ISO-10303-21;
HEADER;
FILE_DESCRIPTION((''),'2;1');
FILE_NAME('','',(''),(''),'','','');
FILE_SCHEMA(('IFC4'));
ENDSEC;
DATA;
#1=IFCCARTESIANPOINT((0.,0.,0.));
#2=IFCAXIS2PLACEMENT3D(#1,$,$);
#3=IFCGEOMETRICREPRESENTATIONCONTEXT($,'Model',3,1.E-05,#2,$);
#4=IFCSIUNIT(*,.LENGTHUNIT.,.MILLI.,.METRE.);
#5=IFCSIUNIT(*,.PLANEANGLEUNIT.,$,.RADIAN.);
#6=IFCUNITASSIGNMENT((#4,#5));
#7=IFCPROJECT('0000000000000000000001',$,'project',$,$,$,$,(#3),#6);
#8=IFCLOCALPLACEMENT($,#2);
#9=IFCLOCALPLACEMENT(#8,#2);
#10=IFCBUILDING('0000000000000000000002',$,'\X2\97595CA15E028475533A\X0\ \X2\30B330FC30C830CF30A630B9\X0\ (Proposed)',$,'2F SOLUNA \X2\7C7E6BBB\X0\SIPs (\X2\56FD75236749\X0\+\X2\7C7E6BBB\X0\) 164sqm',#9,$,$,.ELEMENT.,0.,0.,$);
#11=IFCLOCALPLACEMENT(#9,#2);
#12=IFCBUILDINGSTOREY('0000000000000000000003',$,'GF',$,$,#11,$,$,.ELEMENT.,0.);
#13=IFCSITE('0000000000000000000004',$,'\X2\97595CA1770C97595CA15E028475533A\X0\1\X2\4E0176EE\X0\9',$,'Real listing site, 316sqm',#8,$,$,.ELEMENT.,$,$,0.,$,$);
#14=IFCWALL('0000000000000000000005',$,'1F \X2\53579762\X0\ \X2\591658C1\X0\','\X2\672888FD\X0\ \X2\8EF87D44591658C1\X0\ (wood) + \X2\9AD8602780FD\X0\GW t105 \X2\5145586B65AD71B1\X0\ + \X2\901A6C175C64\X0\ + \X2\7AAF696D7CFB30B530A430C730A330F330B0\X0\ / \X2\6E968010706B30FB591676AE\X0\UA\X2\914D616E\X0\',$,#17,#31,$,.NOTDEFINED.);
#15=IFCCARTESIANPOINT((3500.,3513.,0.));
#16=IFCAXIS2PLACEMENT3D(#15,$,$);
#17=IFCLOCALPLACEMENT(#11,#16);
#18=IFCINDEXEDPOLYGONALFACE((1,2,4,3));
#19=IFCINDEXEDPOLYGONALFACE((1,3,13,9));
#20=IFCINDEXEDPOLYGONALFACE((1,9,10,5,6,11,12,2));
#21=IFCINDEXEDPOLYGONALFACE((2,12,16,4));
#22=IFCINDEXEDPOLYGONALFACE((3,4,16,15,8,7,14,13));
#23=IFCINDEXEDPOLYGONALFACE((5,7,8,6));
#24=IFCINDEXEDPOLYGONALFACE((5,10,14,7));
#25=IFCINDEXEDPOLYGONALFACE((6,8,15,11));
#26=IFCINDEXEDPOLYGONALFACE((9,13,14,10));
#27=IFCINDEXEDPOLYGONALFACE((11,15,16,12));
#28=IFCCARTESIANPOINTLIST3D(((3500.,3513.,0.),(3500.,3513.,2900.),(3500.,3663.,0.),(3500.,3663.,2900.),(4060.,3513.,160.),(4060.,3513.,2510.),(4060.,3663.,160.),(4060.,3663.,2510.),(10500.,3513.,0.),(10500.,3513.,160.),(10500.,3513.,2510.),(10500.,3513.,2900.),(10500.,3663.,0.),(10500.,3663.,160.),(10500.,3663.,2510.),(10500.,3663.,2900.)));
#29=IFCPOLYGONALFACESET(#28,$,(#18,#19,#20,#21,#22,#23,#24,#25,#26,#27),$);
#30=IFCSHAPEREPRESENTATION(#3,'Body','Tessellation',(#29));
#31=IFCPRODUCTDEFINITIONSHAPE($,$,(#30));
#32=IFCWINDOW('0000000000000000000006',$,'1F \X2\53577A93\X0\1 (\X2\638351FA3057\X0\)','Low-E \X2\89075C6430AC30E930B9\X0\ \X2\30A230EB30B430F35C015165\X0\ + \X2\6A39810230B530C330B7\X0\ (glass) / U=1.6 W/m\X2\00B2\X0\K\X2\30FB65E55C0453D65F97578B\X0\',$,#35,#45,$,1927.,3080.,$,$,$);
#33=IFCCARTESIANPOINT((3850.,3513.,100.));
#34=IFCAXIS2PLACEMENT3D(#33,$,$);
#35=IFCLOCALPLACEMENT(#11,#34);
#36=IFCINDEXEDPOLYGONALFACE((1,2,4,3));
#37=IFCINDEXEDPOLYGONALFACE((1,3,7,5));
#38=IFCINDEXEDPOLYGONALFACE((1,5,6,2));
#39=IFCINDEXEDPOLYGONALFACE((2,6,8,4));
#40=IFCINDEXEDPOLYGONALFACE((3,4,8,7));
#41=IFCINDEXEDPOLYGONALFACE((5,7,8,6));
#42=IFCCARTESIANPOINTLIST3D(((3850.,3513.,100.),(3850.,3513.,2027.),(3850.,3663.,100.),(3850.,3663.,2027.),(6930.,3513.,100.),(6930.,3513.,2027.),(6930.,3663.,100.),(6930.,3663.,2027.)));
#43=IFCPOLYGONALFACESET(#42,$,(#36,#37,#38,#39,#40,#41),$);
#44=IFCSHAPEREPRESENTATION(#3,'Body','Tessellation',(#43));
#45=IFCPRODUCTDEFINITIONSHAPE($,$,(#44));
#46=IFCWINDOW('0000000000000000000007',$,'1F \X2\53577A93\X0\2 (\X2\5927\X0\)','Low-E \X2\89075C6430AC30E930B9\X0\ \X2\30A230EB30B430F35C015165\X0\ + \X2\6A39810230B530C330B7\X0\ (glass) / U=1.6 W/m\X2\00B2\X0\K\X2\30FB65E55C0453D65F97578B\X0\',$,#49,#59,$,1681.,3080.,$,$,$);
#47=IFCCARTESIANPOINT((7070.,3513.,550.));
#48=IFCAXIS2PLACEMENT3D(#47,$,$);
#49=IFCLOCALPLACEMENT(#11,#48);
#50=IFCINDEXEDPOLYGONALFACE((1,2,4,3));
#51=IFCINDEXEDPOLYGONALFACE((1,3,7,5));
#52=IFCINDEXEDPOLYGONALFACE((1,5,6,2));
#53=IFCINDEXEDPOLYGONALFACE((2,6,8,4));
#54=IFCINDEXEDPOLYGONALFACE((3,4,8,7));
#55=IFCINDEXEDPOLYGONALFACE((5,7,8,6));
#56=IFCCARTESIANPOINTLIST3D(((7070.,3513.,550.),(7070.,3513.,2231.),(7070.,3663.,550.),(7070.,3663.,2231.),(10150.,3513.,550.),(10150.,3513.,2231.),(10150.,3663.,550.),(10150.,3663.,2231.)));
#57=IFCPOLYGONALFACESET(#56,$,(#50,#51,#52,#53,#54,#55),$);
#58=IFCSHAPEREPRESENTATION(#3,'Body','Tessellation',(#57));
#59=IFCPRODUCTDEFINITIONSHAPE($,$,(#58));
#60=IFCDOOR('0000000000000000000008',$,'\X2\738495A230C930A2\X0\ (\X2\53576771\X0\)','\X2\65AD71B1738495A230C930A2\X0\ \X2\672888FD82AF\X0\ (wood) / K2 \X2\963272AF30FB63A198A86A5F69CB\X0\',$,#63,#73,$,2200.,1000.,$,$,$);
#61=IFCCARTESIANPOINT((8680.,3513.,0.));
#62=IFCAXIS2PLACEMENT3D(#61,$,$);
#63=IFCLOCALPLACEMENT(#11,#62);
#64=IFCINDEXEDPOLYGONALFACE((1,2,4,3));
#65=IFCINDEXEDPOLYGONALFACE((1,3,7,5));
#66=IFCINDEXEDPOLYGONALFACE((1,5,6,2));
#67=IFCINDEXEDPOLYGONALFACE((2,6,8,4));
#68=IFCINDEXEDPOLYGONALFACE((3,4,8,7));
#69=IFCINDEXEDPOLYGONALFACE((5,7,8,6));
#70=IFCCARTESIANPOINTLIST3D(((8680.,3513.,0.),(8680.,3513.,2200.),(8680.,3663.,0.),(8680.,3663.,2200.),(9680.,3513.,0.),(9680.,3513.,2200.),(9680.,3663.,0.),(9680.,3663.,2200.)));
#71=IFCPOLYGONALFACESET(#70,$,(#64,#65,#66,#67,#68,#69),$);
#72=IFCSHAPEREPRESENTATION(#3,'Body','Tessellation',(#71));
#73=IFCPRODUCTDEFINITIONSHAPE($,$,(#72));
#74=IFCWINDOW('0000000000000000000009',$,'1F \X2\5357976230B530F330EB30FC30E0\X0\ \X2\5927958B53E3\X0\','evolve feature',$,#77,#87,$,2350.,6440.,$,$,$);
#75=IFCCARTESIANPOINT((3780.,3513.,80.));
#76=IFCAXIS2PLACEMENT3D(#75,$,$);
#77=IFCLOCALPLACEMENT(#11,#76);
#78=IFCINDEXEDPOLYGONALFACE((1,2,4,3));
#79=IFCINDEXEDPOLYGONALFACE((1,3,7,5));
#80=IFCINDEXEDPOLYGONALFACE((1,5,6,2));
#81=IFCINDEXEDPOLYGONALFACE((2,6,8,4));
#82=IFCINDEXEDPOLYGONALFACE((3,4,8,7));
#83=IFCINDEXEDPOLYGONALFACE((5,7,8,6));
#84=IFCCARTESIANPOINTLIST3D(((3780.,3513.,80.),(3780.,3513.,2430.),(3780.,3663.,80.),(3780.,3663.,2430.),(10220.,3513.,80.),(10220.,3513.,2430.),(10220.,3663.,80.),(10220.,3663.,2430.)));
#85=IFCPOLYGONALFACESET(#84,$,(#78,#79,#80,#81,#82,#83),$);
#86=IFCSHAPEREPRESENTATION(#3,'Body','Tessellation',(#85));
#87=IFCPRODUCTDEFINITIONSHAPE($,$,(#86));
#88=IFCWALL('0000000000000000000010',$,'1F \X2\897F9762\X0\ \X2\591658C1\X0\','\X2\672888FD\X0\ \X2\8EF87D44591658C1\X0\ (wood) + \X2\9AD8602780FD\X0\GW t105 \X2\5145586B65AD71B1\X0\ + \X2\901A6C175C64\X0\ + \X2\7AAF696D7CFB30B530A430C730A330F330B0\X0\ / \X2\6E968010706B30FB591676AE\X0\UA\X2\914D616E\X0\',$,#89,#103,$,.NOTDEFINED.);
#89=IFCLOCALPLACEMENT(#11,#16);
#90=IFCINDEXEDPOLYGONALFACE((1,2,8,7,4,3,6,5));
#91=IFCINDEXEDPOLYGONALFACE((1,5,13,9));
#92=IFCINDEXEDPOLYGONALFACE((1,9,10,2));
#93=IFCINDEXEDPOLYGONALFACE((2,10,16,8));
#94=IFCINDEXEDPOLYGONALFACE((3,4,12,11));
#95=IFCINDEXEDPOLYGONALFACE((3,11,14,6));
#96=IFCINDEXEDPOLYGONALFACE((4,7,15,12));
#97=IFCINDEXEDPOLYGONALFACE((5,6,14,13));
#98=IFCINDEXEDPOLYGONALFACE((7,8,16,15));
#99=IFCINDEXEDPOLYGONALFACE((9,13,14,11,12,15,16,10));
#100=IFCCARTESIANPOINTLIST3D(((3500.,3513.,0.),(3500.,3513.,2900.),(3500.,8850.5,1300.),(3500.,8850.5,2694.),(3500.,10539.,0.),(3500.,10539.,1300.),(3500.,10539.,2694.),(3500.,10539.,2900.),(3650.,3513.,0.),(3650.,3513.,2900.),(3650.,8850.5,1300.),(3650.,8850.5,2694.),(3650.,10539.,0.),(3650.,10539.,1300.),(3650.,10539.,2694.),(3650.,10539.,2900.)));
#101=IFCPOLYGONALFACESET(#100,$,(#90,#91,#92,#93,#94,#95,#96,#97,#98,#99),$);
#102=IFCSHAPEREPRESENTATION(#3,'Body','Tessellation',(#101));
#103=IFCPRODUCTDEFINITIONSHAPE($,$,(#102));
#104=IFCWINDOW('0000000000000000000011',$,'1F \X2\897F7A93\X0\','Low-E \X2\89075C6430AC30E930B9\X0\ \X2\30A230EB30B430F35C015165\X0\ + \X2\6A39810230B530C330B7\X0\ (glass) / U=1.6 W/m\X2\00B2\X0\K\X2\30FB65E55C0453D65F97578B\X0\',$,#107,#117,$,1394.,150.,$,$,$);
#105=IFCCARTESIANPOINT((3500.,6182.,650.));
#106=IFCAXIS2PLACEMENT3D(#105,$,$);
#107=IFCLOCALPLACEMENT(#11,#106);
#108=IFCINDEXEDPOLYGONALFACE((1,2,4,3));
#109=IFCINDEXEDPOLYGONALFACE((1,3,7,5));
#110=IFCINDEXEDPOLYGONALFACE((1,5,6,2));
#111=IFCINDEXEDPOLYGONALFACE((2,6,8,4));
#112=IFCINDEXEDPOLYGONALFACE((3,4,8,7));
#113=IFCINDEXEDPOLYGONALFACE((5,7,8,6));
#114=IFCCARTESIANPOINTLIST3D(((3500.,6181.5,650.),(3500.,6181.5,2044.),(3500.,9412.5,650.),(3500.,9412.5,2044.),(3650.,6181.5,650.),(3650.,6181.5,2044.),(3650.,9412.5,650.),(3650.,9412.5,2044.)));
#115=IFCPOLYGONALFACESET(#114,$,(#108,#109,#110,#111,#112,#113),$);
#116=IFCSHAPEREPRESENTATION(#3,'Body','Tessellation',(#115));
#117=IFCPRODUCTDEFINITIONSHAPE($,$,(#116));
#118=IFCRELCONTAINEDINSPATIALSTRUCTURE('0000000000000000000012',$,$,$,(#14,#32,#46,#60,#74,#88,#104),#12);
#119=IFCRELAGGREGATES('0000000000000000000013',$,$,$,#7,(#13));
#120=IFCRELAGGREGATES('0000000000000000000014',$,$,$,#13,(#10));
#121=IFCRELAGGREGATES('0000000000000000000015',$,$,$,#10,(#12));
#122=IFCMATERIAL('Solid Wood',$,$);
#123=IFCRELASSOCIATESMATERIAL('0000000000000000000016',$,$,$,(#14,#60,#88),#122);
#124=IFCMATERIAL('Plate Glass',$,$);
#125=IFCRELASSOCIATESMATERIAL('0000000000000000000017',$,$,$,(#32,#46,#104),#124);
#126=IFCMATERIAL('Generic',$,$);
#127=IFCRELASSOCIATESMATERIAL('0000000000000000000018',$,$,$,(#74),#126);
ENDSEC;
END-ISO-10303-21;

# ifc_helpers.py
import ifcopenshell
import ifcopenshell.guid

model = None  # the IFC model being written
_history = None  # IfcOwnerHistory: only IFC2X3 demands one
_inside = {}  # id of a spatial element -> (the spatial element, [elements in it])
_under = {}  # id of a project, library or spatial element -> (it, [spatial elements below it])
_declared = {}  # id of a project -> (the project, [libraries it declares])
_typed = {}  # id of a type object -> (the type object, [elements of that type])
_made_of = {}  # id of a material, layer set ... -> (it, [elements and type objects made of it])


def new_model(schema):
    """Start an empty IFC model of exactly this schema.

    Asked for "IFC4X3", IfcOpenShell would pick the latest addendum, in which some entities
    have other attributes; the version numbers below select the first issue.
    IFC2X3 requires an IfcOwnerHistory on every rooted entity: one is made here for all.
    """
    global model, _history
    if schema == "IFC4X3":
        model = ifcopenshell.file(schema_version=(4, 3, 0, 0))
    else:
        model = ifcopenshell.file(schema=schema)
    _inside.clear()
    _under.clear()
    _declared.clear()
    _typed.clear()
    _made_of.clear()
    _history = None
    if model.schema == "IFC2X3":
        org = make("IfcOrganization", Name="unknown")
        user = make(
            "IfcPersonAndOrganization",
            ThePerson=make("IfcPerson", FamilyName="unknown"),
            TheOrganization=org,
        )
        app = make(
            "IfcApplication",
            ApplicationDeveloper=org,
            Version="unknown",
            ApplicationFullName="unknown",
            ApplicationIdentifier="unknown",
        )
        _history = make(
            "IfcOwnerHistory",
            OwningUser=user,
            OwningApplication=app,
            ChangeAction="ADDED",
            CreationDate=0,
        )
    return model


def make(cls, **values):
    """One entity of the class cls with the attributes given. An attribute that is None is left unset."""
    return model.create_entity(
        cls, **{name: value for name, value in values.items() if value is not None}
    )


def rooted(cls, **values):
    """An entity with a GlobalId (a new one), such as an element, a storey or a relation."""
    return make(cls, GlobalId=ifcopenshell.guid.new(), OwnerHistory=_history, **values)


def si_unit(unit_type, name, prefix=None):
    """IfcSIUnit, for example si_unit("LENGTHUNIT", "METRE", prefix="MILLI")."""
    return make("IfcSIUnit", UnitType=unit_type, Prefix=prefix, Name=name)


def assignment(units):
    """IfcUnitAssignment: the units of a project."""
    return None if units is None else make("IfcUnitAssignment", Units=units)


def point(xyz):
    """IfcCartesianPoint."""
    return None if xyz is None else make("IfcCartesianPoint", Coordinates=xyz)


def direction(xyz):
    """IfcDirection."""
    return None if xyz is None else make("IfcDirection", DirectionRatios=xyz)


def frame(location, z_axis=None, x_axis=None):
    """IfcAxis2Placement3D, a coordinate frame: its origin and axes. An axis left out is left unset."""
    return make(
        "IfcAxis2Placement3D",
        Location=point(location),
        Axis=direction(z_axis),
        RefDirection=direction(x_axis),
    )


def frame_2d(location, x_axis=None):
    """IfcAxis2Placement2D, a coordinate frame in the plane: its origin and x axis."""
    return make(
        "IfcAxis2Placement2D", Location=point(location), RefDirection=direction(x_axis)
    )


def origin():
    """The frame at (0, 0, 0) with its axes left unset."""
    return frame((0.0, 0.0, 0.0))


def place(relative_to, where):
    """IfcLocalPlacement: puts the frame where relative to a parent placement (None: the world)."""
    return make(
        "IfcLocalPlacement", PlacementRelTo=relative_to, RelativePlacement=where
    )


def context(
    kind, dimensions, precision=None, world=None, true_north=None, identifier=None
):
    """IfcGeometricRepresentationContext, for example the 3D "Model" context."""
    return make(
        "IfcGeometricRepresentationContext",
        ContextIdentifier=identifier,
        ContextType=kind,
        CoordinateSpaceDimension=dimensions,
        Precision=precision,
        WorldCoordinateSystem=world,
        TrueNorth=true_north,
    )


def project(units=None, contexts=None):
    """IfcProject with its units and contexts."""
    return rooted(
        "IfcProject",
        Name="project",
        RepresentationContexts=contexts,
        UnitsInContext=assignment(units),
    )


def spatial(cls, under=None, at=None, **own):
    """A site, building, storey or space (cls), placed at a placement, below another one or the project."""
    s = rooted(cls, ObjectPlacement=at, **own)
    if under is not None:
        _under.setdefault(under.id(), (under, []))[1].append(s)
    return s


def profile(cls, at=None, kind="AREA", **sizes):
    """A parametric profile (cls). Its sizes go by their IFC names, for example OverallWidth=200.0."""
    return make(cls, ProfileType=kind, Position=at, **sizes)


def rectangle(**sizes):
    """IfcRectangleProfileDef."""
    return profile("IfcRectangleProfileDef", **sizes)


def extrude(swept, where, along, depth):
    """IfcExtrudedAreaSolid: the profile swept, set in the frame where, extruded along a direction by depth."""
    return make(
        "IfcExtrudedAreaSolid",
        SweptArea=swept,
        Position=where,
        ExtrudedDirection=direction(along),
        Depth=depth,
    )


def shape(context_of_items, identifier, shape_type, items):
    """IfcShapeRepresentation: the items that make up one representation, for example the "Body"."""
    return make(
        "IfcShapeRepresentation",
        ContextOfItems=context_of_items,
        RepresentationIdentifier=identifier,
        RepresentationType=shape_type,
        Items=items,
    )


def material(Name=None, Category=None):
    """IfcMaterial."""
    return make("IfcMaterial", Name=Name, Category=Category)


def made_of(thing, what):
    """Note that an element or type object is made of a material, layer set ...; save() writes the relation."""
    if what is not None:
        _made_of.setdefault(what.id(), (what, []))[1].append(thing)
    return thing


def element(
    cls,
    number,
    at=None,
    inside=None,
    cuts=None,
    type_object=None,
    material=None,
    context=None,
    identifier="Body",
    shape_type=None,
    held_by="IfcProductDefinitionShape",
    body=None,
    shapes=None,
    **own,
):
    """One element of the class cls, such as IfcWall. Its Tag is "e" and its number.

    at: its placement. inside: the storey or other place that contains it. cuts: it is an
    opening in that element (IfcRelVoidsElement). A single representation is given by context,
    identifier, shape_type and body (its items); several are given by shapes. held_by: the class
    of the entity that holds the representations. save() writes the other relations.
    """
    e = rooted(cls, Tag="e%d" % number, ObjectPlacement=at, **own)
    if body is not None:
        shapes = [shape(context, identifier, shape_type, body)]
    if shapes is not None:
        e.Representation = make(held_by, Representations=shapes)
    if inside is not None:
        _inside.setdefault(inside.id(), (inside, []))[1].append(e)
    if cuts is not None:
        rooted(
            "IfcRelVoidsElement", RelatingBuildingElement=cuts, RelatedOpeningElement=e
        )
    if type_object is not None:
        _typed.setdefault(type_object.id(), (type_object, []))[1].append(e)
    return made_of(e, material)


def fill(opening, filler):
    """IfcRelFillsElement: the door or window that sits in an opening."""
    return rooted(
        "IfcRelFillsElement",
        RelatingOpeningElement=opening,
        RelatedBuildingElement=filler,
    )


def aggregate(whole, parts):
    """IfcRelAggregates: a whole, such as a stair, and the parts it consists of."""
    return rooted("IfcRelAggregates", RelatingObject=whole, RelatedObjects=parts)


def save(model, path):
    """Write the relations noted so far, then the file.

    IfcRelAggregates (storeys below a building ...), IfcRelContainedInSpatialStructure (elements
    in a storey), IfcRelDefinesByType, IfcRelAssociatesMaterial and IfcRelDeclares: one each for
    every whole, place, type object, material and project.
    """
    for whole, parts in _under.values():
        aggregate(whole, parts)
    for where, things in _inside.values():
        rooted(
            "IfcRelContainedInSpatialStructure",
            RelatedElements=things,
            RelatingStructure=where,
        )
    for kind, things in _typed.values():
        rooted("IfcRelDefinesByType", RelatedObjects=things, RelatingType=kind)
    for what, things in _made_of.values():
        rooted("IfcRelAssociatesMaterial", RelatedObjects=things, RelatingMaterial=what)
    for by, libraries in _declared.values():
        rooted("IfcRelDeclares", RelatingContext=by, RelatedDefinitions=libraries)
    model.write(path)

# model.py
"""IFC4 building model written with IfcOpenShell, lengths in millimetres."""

from ifc_helpers import new_model, si_unit, frame, frame_2d, origin, place, context, project, spatial, rectangle, extrude, material, element, fill, save


model = new_model("IFC4")

# Units and contexts
model_context = context("Model", 3, precision=1e-05, world=origin())
ifc_project = project(units=[si_unit("LENGTHUNIT", "METRE", prefix="MILLI"), si_unit("PLANEANGLEUNIT", "RADIAN")], contexts=[model_context])

# Site, building, storey
site_placement = place(None, origin())
site = spatial("IfcSite", under=ifc_project, at=site_placement, Name="静岡県静岡市葵区1丁目9", ObjectType="Real listing site, 316sqm", CompositionType="ELEMENT", RefElevation=0.0)
building_placement = place(site_placement, origin())
building = spatial("IfcBuilding", under=site, at=building_placement, Name="静岡市葵区 コートハウス (Proposed)", ObjectType="2F SOLUNA 籾殻SIPs (国産杉+籾殻) 164sqm", CompositionType="ELEMENT", ElevationOfRefHeight=0.0, ElevationOfTerrain=0.0)
storey_placement = place(building_placement, origin())
storey = spatial("IfcBuildingStorey", under=building, at=storey_placement, Name="GF", CompositionType="ELEMENT", Elevation=0.0)

# Shared definitions
ifc_material_1 = material(Name="Solid Wood")
ifc_material_2 = material(Name="Generic")

# Wall, openings, windows, door
wall_1_placement = place(storey_placement, frame((3500.0, 3513.0, 0.0)))
wall_1 = element("IfcWall", 1, at=wall_1_placement, inside=storey, material=ifc_material_1, Name="1F 南面 外壁", Description="木製 軸組外壁 (wood) + 高性能GW t105 充填断熱 + 通気層 + 窯業系サイディング / 準耐火・外皮UA配慮", PredefinedType="NOTDEFINED", context=model_context, shape_type="SweptSolid", body=[
    extrude(rectangle(XDim=7000.0, YDim=150.0, at=frame_2d((3500.0, 75.0))), frame((3500.0, 3513.0, 0.0)), (0.0, 0.0, 1.0), 2900.0),
])
opening_1_placement = place(storey_placement, frame((3850.0, 3513.0, 100.0)))
opening_1 = element("IfcOpeningElement", 2, at=opening_1_placement, cuts=wall_1, PredefinedType="NOTDEFINED", context=model_context, shape_type="SweptSolid", body=[
    extrude(rectangle(XDim=3080.0, YDim=150.0, at=frame_2d((1540.0, 75.0))), frame((3850.0, 3513.0, 100.0)), (0.0, 0.0, 1.0), 1927.0),
])
opening_2_placement = place(storey_placement, frame((7070.0, 3513.0, 550.0)))
opening_2 = element("IfcOpeningElement", 3, at=opening_2_placement, cuts=wall_1, PredefinedType="NOTDEFINED", context=model_context, shape_type="SweptSolid", body=[
    extrude(rectangle(XDim=3080.0, YDim=150.0, at=frame_2d((1540.0, 75.0))), frame((7070.0, 3513.0, 550.0)), (0.0, 0.0, 1.0), 1681.0),
])
opening_3_placement = place(storey_placement, frame((8680.0, 3513.0, 0.0)))
opening_3 = element("IfcOpeningElement", 4, at=opening_3_placement, cuts=wall_1, PredefinedType="NOTDEFINED", context=model_context, shape_type="SweptSolid", body=[
    extrude(rectangle(XDim=1000.0, YDim=150.0, at=frame_2d((500.0, 75.0))), frame((8680.0, 3513.0, 0.0)), (0.0, 0.0, 1.0), 2200.0),
])
opening_4_placement = place(storey_placement, frame((3780.0, 3513.0, 80.0)))
opening_4 = element("IfcOpeningElement", 5, at=opening_4_placement, cuts=wall_1, PredefinedType="NOTDEFINED", context=model_context, shape_type="SweptSolid", body=[
    extrude(rectangle(XDim=6440.0, YDim=150.0, at=frame_2d((3220.0, 75.0))), frame((3780.0, 3513.0, 80.0)), (0.0, 0.0, 1.0), 2350.0),
])
ifc_material_3 = material(Name="Plate Glass")
window_1_placement = place(storey_placement, frame((3850.0, 3513.0, 100.0)))
window_1 = element("IfcWindow", 6, at=window_1_placement, inside=storey, material=ifc_material_3, Name="1F 南窓1 (掃出し)", Description="Low-E 複層ガラス アルゴン封入 + 樹脂サッシ (glass) / U=1.6 W/m²K・日射取得型", OverallHeight=1927.0, OverallWidth=3080.0, context=model_context, shape_type="SweptSolid", body=[
    extrude(rectangle(XDim=3080.0, YDim=150.0, at=frame_2d((1540.0, 75.0))), frame((3850.0, 3513.0, 100.0)), (0.0, 0.0, 1.0), 1927.0),
])
fill(opening_1, window_1)
window_2_placement = place(storey_placement, frame((7070.0, 3513.0, 550.0)))
window_2 = element("IfcWindow", 7, at=window_2_placement, inside=storey, material=ifc_material_3, Name="1F 南窓2 (大)", Description="Low-E 複層ガラス アルゴン封入 + 樹脂サッシ (glass) / U=1.6 W/m²K・日射取得型", OverallHeight=1681.0, OverallWidth=3080.0, context=model_context, shape_type="SweptSolid", body=[
    extrude(rectangle(XDim=3080.0, YDim=150.0, at=frame_2d((1540.0, 75.0))), frame((7070.0, 3513.0, 550.0)), (0.0, 0.0, 1.0), 1681.0),
])
fill(opening_2, window_2)
door_placement = place(storey_placement, frame((8680.0, 3513.0, 0.0)))
door = element("IfcDoor", 8, at=door_placement, inside=storey, material=ifc_material_1, Name="玄関ドア (南東)", Description="断熱玄関ドア 木製芯 (wood) / K2 防犯・採風機構", OverallHeight=2200.0, OverallWidth=1000.0, context=model_context, shape_type="SweptSolid", body=[
    extrude(rectangle(XDim=1000.0, YDim=150.0, at=frame_2d((500.0, 75.0))), frame((8680.0, 3513.0, 0.0)), (0.0, 0.0, 1.0), 2200.0),
])
fill(opening_3, door)
window_3_placement = place(storey_placement, frame((3780.0, 3513.0, 80.0)))
window_3 = element("IfcWindow", 9, at=window_3_placement, inside=storey, material=ifc_material_2, Name="1F 南面サンルーム 大開口", Description="evolve feature", OverallHeight=2350.0, OverallWidth=6440.0, context=model_context, shape_type="SweptSolid", body=[
    extrude(rectangle(XDim=6440.0, YDim=150.0, at=frame_2d((3220.0, 75.0))), frame((3780.0, 3513.0, 80.0)), (0.0, 0.0, 1.0), 2350.0),
])
fill(opening_4, window_3)

# Wall, opening, window
wall_2_placement = place(storey_placement, frame((3500.0, 3513.0, 0.0)))
wall_2 = element("IfcWall", 10, at=wall_2_placement, inside=storey, material=ifc_material_1, Name="1F 西面 外壁", Description="木製 軸組外壁 (wood) + 高性能GW t105 充填断熱 + 通気層 + 窯業系サイディング / 準耐火・外皮UA配慮", PredefinedType="NOTDEFINED", context=model_context, shape_type="SweptSolid", body=[
    extrude(rectangle(XDim=150.0, YDim=7026.0, at=frame_2d((75.0, 3513.0))), frame((3500.0, 3513.0, 0.0)), (0.0, 0.0, 1.0), 2900.0),
])
opening_5_placement = place(storey_placement, frame((3500.0, 6182.0, 650.0)))
opening_5 = element("IfcOpeningElement", 11, at=opening_5_placement, cuts=wall_2, PredefinedType="NOTDEFINED", context=model_context, shape_type="SweptSolid", body=[
    extrude(rectangle(XDim=150.0, YDim=3231.0, at=frame_2d((75.0, 1615.0))), frame((3500.0, 6182.0, 650.0)), (0.0, 0.0, 1.0), 1394.0),
])
window_4_placement = place(storey_placement, frame((3500.0, 6182.0, 650.0)))
window_4 = element("IfcWindow", 12, at=window_4_placement, inside=storey, material=ifc_material_3, Name="1F 西窓", Description="Low-E 複層ガラス アルゴン封入 + 樹脂サッシ (glass) / U=1.6 W/m²K・日射取得型", OverallHeight=1394.0, OverallWidth=150.0, context=model_context, shape_type="SweptSolid", body=[
    extrude(rectangle(XDim=150.0, YDim=3231.0, at=frame_2d((75.0, 1615.0))), frame((3500.0, 6182.0, 650.0)), (0.0, 0.0, 1.0), 1394.0),
])
fill(opening_5, window_4)

save(model, "model.ifc")
